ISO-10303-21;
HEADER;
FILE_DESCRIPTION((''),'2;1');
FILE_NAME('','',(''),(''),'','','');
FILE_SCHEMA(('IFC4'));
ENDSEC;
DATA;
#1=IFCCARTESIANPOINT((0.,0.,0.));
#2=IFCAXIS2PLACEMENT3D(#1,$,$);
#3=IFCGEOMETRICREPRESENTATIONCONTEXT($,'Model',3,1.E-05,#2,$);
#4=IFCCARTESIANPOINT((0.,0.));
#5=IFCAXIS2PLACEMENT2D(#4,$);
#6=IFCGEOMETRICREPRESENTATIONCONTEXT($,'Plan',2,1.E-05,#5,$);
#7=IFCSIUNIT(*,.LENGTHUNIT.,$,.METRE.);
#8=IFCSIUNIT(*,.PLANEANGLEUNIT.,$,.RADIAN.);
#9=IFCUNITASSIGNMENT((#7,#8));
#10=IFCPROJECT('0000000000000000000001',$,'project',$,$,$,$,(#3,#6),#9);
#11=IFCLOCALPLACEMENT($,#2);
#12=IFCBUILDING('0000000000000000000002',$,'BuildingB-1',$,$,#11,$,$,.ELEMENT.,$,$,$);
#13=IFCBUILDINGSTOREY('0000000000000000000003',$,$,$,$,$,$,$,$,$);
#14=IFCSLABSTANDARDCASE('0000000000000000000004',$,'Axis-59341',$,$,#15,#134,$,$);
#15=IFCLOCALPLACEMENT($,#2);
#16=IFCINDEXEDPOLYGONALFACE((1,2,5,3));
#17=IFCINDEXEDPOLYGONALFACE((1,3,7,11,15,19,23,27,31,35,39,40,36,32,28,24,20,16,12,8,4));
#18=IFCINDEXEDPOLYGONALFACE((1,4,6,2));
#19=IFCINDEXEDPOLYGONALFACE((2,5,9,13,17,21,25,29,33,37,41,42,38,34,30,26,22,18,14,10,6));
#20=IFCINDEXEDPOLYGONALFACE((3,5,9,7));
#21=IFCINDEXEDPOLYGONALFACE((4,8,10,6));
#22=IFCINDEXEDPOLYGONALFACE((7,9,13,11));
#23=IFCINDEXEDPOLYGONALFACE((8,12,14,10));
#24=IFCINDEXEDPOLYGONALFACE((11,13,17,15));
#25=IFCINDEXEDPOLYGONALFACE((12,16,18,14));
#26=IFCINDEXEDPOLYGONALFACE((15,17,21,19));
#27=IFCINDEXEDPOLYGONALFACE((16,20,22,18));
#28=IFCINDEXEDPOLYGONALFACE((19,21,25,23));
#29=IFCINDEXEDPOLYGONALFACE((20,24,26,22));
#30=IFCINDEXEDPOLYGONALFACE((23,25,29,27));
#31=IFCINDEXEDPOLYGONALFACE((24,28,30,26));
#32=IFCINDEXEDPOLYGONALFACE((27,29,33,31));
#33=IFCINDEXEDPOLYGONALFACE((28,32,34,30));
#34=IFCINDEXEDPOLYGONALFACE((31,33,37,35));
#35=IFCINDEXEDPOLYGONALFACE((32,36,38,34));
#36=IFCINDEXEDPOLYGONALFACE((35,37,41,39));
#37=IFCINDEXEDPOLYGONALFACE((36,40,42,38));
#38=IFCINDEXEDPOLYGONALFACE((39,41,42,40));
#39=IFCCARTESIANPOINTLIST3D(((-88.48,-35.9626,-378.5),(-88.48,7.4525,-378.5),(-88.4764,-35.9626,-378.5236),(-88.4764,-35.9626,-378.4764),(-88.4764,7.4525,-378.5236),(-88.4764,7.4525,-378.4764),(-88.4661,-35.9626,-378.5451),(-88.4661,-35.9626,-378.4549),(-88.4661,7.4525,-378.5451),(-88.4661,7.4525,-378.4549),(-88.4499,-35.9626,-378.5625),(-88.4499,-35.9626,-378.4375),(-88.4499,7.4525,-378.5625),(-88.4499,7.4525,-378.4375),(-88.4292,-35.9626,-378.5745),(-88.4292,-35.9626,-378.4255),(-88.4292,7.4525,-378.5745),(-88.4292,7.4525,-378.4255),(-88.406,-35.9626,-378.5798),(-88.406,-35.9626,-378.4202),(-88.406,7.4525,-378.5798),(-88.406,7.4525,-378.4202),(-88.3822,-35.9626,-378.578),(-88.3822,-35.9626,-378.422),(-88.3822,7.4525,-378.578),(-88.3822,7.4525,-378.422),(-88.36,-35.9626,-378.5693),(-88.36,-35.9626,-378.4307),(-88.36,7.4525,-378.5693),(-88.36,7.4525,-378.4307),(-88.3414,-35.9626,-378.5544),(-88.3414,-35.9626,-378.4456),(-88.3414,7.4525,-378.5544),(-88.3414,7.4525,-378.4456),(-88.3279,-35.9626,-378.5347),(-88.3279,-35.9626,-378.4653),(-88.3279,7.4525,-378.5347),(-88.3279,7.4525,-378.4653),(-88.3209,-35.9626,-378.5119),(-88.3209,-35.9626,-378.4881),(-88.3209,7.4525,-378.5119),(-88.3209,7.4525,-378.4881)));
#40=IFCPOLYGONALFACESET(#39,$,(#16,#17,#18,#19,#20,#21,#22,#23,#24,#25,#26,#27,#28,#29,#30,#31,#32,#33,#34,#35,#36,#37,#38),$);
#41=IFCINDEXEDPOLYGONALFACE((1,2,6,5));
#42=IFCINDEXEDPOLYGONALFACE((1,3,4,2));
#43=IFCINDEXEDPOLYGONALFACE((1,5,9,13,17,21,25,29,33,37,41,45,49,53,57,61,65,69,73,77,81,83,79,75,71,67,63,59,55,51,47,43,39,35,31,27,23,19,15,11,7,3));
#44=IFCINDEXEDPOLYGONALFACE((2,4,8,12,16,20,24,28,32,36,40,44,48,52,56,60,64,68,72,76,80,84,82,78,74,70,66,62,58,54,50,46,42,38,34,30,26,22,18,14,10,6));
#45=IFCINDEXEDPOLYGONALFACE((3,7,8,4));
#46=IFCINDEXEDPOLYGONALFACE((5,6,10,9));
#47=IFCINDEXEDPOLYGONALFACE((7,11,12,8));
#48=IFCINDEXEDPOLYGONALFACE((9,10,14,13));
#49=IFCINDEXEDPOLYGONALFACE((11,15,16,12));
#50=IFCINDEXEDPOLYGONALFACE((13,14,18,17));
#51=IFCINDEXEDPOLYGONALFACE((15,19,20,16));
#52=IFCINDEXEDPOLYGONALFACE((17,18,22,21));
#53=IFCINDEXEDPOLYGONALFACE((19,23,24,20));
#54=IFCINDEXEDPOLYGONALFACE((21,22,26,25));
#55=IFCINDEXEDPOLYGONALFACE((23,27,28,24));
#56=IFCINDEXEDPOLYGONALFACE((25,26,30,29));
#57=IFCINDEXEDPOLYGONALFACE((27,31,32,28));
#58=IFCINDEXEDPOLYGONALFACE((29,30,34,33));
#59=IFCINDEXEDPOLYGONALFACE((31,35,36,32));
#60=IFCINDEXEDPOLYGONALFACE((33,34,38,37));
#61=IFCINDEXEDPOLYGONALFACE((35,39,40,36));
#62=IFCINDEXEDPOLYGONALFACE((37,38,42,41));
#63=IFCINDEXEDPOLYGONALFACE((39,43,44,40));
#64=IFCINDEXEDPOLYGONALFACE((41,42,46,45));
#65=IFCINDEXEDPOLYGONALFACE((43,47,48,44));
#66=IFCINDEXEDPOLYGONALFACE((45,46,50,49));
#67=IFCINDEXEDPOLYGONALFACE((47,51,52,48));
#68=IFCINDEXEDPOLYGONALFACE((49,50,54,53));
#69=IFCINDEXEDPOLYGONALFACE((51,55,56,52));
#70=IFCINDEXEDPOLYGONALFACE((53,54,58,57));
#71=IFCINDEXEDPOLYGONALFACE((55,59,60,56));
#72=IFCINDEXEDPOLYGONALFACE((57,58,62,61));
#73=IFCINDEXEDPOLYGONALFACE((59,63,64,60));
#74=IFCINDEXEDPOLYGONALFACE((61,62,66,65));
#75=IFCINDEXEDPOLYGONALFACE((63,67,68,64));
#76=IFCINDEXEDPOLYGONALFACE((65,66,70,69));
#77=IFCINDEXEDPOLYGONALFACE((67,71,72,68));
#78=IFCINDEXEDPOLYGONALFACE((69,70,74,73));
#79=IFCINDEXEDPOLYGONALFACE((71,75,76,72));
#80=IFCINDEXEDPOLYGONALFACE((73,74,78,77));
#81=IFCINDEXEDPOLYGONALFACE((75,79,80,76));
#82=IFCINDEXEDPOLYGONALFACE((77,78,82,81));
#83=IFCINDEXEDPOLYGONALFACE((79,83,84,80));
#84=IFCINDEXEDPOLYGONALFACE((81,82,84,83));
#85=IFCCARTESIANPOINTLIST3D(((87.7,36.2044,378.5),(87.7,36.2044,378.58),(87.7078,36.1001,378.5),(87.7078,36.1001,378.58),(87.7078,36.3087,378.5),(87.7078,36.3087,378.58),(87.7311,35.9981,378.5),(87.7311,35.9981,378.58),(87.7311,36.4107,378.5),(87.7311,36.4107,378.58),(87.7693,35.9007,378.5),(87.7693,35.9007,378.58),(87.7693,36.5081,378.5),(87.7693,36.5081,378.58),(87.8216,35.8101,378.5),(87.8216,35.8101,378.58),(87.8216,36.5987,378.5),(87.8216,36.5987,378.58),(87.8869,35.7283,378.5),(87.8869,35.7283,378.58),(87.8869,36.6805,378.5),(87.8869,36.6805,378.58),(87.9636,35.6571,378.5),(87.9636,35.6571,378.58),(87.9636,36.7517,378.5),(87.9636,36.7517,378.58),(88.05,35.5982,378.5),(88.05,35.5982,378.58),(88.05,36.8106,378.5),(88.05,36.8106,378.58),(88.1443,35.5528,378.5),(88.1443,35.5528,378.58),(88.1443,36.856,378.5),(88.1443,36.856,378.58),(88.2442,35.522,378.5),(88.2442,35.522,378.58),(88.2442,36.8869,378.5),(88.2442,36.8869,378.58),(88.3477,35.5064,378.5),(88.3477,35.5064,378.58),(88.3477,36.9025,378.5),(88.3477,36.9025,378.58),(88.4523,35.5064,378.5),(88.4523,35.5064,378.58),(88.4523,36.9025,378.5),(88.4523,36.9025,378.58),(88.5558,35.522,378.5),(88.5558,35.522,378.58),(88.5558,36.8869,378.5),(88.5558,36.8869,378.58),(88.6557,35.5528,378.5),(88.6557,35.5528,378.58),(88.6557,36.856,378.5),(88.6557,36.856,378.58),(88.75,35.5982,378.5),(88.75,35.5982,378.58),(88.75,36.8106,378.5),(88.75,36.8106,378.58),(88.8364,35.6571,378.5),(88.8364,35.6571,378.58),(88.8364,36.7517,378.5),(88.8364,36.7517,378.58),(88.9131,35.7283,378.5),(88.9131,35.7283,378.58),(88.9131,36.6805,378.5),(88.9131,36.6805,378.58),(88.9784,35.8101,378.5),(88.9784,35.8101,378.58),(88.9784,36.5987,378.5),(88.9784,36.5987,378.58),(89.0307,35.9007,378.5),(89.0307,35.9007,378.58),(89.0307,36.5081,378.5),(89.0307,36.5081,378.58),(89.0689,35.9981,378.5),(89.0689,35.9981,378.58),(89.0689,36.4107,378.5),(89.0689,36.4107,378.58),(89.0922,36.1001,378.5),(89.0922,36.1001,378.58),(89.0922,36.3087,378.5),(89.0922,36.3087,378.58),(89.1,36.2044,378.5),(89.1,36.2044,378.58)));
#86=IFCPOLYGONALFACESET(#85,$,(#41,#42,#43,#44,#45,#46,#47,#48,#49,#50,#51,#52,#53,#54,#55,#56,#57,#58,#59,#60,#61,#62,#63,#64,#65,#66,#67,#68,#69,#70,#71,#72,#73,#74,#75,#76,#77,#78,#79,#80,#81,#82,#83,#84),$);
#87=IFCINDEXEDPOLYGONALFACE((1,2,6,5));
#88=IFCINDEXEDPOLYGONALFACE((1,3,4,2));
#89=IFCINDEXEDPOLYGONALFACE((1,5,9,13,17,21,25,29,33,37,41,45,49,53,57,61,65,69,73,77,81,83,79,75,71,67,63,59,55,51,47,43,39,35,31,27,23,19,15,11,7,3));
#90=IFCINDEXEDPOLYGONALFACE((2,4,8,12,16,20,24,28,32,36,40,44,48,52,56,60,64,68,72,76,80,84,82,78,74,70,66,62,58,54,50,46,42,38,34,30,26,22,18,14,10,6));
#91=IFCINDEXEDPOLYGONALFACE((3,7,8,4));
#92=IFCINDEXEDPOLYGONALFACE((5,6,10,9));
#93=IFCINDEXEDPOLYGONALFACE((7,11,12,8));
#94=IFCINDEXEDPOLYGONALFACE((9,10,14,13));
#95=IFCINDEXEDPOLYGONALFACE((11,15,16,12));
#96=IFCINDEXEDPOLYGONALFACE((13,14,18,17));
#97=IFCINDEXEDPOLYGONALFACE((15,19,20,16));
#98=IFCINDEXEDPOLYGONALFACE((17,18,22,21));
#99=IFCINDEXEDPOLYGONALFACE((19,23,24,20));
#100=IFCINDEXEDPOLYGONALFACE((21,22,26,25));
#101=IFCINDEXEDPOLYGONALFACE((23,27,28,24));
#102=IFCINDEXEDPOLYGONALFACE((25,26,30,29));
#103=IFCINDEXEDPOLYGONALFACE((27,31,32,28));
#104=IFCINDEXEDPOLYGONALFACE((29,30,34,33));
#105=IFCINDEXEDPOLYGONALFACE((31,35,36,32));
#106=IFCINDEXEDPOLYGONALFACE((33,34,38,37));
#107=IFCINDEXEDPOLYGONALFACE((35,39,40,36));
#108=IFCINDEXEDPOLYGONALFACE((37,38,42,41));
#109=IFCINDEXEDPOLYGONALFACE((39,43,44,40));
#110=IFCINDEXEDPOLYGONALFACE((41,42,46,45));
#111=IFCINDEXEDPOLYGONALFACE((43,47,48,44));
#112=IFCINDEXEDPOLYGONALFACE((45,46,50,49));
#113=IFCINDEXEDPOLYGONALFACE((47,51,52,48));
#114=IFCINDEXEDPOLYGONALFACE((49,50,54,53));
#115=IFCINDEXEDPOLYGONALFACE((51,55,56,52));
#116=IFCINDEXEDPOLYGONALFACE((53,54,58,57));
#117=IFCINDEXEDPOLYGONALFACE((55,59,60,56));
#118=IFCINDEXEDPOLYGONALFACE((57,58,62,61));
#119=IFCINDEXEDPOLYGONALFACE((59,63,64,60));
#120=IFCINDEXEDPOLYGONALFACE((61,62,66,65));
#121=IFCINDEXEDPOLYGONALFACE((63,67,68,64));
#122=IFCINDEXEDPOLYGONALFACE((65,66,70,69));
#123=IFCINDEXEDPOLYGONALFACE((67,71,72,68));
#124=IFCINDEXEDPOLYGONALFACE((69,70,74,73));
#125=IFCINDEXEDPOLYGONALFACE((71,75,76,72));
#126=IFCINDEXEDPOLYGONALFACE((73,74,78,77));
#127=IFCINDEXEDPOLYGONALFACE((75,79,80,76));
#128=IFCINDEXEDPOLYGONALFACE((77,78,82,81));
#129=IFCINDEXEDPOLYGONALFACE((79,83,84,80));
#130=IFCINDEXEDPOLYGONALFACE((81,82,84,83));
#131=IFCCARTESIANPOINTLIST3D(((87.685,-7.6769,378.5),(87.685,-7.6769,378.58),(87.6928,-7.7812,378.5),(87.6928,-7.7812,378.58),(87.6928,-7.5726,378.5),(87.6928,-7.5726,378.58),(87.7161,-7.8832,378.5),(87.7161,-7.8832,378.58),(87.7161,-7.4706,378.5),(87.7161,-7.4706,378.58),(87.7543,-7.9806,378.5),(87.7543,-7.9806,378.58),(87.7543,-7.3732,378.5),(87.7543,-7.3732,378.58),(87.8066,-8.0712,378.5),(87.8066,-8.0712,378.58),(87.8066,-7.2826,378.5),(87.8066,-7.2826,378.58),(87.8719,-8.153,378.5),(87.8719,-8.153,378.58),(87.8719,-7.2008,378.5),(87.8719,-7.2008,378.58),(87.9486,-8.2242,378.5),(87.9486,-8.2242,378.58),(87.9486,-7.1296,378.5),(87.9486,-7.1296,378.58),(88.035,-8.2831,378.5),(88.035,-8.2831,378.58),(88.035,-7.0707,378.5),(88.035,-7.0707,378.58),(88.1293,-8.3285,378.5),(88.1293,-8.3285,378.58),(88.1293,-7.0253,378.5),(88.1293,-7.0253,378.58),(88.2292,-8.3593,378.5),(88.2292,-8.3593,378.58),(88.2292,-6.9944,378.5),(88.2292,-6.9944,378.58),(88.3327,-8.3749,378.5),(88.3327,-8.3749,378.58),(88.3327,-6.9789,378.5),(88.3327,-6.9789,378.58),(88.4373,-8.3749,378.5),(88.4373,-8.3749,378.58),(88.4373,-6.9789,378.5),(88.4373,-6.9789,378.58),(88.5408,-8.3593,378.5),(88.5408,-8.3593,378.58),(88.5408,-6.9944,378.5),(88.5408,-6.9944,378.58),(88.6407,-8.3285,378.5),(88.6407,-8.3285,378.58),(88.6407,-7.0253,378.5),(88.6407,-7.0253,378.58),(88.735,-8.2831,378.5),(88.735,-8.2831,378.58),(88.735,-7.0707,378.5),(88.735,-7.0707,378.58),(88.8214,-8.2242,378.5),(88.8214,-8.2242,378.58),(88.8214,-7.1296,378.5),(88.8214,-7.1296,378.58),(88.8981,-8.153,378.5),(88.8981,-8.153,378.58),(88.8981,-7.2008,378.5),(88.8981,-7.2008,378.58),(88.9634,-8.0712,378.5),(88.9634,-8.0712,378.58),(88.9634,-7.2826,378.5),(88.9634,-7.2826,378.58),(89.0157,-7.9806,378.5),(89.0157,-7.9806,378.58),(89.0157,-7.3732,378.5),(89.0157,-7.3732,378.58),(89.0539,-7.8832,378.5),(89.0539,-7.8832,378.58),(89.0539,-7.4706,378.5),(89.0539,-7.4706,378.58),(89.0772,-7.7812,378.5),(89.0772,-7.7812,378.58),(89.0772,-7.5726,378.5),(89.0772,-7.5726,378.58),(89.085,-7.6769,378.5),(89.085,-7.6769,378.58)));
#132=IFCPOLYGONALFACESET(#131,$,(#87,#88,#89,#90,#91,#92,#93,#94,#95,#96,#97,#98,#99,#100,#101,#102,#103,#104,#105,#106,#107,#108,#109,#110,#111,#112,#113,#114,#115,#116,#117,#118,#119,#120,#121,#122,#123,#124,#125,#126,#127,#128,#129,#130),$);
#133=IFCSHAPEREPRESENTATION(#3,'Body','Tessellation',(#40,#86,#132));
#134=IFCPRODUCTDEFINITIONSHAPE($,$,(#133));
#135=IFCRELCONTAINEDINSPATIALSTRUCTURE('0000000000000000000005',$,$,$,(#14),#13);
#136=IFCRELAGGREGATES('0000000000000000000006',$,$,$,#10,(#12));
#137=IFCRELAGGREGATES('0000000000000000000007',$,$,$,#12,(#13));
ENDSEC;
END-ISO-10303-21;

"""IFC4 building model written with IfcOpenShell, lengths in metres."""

from ifc_helpers import new_model, entity, si_unit, frame, origin, origin_2d, place, context, project, spatial, circle, extrude, element, save


model = new_model("IFC4")

# Units and contexts
model_context = context("Model", 3, precision=1e-05, world=origin())
plan_context = context("Plan", 2, precision=1e-05, world=origin_2d())
ifc_project = project(units=[si_unit("LENGTHUNIT", "METRE"), si_unit("PLANEANGLEUNIT", "RADIAN")], contexts=[model_context, plan_context])

# Building, storey
building_placement = place(None, origin())
building = spatial("IfcBuilding", under=ifc_project, at=building_placement, Name="BuildingB-1", CompositionType="ELEMENT")
storey = spatial("IfcBuildingStorey", under=building)

# Slab
element("IfcSlabStandardCase", 1, inside=storey, Name="Axis-59341", context=model_context, shape_type="AdvancedSweptSolid", body=[
    entity("IfcSurfaceCurveSweptAreaSolid", entity("IfcCircleProfileDef", "AREA", None, None, 0.08), None, entity("IfcPolyline", [entity("IfcCartesianPoint", [88.4, 35.9626, 378.5]), entity("IfcCartesianPoint", [88.4, -7.4525, 378.5])]), None, None, entity("IfcPlane", entity("IfcAxis2Placement3D", entity("IfcCartesianPoint", [88.4, 35.9626, 378.5]), entity("IfcDirection", [0.0, 0.0, 1.0]), entity("IfcDirection", [1.0, 0.0, 0.0])))),
    extrude(circle(Radius=0.7), frame((88.4, 36.2044, 378.5)), (0.0, 0.0, 1.0), 0.08),
    extrude(circle(Radius=0.7), frame((88.385, -7.6769, 378.5)), (0.0, 0.0, 1.0), 0.08),
])

save(model, "model.ifc")
